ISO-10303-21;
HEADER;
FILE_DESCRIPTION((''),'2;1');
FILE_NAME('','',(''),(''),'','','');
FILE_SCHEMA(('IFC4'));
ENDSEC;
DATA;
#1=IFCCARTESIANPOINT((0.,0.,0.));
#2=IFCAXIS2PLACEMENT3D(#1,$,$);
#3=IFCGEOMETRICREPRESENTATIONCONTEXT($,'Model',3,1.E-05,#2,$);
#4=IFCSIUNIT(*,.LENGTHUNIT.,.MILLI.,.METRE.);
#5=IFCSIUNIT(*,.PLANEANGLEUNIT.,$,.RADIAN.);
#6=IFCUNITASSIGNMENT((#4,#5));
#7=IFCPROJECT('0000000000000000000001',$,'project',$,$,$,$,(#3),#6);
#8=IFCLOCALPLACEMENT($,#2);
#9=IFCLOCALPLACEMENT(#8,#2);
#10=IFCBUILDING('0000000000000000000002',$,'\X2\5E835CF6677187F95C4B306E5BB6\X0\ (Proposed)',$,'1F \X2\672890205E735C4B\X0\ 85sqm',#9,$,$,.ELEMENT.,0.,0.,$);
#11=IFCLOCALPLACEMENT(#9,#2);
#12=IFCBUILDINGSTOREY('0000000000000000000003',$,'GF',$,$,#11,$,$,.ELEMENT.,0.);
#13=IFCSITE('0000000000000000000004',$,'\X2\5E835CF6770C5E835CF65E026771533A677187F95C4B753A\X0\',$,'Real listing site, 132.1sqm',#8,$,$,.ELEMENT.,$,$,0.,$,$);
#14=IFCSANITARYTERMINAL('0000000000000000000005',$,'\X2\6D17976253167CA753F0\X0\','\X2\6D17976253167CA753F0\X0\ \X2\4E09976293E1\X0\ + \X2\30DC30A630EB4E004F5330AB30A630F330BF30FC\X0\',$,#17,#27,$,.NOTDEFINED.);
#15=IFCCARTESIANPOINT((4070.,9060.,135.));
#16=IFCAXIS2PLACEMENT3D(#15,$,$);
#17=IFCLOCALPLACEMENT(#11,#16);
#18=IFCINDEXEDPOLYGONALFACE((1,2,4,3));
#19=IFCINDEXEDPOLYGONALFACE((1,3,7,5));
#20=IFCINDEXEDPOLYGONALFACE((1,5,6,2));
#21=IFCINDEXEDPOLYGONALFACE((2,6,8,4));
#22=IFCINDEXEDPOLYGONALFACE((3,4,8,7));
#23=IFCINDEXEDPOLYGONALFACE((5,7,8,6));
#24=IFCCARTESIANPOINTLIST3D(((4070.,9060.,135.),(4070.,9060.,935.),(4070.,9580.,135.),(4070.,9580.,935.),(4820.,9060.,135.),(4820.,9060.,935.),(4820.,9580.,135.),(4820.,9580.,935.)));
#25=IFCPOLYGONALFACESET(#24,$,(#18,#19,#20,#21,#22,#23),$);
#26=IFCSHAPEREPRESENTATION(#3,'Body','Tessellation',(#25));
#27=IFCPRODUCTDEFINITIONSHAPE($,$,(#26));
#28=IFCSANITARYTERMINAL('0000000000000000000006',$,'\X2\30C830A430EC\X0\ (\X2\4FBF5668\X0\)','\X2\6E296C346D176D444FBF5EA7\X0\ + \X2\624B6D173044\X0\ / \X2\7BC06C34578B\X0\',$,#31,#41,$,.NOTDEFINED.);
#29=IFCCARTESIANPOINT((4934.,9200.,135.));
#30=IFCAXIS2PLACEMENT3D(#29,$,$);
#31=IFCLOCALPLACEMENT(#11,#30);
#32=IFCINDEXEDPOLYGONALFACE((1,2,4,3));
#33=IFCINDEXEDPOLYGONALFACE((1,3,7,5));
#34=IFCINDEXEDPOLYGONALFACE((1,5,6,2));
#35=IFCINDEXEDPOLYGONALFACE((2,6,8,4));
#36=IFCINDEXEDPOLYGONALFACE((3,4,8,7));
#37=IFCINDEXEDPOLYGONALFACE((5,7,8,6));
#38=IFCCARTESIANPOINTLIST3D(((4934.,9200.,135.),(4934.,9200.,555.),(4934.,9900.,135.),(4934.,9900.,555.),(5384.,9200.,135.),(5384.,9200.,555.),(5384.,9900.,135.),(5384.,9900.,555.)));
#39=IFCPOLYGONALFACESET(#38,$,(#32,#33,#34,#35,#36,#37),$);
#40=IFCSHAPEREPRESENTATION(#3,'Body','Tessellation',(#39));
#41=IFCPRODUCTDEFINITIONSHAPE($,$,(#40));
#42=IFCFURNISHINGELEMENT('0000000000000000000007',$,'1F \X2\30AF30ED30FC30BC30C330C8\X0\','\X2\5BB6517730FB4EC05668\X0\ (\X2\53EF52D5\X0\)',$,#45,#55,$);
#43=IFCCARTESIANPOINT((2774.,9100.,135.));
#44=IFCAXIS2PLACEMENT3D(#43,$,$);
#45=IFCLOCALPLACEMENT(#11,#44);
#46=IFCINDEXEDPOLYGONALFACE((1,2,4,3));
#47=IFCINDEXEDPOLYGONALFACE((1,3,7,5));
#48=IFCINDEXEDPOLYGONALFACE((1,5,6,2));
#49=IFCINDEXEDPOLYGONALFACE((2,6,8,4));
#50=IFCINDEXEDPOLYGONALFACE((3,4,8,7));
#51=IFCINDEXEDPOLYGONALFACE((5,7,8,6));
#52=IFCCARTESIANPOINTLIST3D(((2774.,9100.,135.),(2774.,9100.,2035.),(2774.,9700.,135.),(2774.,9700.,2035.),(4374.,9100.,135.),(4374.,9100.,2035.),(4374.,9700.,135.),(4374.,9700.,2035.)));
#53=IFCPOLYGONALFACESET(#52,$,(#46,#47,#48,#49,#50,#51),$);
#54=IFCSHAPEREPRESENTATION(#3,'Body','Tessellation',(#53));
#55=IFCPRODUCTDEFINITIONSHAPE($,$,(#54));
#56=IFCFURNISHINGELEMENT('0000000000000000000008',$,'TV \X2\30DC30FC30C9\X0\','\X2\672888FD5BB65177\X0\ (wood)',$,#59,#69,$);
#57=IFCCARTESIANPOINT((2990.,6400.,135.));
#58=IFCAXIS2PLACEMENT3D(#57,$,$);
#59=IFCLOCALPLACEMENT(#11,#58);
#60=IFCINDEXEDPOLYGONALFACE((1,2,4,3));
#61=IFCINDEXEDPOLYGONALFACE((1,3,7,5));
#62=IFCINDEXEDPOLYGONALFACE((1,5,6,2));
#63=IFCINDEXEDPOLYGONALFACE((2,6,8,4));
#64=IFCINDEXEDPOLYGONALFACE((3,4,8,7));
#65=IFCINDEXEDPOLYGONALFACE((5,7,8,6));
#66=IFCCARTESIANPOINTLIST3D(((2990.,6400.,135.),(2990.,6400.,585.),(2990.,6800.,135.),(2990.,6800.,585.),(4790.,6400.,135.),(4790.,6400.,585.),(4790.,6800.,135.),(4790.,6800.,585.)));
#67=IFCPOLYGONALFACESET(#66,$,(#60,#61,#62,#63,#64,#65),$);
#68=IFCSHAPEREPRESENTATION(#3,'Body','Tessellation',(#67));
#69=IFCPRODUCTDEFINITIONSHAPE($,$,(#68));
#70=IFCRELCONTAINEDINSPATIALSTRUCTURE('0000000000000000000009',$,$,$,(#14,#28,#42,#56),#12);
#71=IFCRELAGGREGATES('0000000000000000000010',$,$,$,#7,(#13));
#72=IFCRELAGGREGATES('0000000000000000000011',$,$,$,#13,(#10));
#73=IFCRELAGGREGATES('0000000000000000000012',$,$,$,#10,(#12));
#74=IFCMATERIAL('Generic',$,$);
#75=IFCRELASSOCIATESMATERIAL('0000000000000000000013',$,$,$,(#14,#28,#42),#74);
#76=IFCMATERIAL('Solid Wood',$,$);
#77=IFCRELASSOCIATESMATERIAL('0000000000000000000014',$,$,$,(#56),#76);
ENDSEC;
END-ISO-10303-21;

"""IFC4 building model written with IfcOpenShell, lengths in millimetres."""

from ifc_helpers import new_model, si_unit, frame, frame_2d, origin, place, context, project, spatial, rectangle, extrude, material, element, save


model = new_model("IFC4")

# Units and contexts
model_context = context("Model", 3, precision=1e-05, world=origin())
ifc_project = project(units=[si_unit("LENGTHUNIT", "METRE", prefix="MILLI"), si_unit("PLANEANGLEUNIT", "RADIAN")], contexts=[model_context])

# Site, building, storey
site_placement = place(None, origin())
site = spatial("IfcSite", under=ifc_project, at=site_placement, Name="広島県広島市東区東蟹屋町", ObjectType="Real listing site, 132.1sqm", CompositionType="ELEMENT", RefElevation=0.0)
building_placement = place(site_placement, origin())
building = spatial("IfcBuilding", under=site, at=building_placement, Name="広島東蟹屋の家 (Proposed)", ObjectType="1F 木造平屋 85sqm", CompositionType="ELEMENT", ElevationOfRefHeight=0.0, ElevationOfTerrain=0.0)
storey_placement = place(building_placement, origin())
storey = spatial("IfcBuildingStorey", under=building, at=storey_placement, Name="GF", CompositionType="ELEMENT", Elevation=0.0)

# Shared definitions
ifc_material_1 = material(Name="Solid Wood")

# Shared definitions
ifc_material_2 = material(Name="Generic")

# Sanitary terminals
sanitary_terminal_1_placement = place(storey_placement, frame((4070.0, 9060.0, 135.0)))
element("IfcSanitaryTerminal", 1, at=sanitary_terminal_1_placement, inside=storey, material=ifc_material_2, Name="洗面化粧台", Description="洗面化粧台 三面鏡 + ボウル一体カウンター", PredefinedType="NOTDEFINED", context=model_context, shape_type="SweptSolid", body=[
    extrude(rectangle(XDim=750.0, YDim=520.0, at=frame_2d((375.0, 260.0))), frame((4070.0, 9060.0, 135.0)), (0.0, 0.0, 1.0), 800.0),
])
sanitary_terminal_2_placement = place(storey_placement, frame((4934.0, 9200.0, 135.0)))
element("IfcSanitaryTerminal", 2, at=sanitary_terminal_2_placement, inside=storey, material=ifc_material_2, Name="トイレ (便器)", Description="温水洗浄便座 + 手洗い / 節水型", PredefinedType="NOTDEFINED", context=model_context, shape_type="SweptSolid", body=[
    extrude(rectangle(XDim=450.0, YDim=700.0, at=frame_2d((225.0, 350.0))), frame((4934.0, 9200.0, 135.0)), (0.0, 0.0, 1.0), 420.0),
])

# Furnishing elements
furnishing_1_placement = place(storey_placement, frame((2774.0, 9100.0, 135.0)))
element("IfcFurnishingElement", 3, at=furnishing_1_placement, inside=storey, material=ifc_material_2, Name="1F クローゼット", Description="家具・什器 (可動)", context=model_context, shape_type="SweptSolid", body=[
    extrude(rectangle(XDim=1600.0, YDim=600.0, at=frame_2d((800.0, 300.0))), frame((2774.0, 9100.0, 135.0)), (0.0, 0.0, 1.0), 1900.0),
])
furnishing_2_placement = place(storey_placement, frame((2990.0, 6400.0, 135.0)))
element("IfcFurnishingElement", 4, at=furnishing_2_placement, inside=storey, material=ifc_material_1, Name="TV ボード", Description="木製家具 (wood)", context=model_context, shape_type="SweptSolid", body=[
    extrude(rectangle(XDim=1800.0, YDim=400.0, at=frame_2d((900.0, 200.0))), frame((2990.0, 6400.0, 135.0)), (0.0, 0.0, 1.0), 450.0),
])

save(model, "model.ifc")
